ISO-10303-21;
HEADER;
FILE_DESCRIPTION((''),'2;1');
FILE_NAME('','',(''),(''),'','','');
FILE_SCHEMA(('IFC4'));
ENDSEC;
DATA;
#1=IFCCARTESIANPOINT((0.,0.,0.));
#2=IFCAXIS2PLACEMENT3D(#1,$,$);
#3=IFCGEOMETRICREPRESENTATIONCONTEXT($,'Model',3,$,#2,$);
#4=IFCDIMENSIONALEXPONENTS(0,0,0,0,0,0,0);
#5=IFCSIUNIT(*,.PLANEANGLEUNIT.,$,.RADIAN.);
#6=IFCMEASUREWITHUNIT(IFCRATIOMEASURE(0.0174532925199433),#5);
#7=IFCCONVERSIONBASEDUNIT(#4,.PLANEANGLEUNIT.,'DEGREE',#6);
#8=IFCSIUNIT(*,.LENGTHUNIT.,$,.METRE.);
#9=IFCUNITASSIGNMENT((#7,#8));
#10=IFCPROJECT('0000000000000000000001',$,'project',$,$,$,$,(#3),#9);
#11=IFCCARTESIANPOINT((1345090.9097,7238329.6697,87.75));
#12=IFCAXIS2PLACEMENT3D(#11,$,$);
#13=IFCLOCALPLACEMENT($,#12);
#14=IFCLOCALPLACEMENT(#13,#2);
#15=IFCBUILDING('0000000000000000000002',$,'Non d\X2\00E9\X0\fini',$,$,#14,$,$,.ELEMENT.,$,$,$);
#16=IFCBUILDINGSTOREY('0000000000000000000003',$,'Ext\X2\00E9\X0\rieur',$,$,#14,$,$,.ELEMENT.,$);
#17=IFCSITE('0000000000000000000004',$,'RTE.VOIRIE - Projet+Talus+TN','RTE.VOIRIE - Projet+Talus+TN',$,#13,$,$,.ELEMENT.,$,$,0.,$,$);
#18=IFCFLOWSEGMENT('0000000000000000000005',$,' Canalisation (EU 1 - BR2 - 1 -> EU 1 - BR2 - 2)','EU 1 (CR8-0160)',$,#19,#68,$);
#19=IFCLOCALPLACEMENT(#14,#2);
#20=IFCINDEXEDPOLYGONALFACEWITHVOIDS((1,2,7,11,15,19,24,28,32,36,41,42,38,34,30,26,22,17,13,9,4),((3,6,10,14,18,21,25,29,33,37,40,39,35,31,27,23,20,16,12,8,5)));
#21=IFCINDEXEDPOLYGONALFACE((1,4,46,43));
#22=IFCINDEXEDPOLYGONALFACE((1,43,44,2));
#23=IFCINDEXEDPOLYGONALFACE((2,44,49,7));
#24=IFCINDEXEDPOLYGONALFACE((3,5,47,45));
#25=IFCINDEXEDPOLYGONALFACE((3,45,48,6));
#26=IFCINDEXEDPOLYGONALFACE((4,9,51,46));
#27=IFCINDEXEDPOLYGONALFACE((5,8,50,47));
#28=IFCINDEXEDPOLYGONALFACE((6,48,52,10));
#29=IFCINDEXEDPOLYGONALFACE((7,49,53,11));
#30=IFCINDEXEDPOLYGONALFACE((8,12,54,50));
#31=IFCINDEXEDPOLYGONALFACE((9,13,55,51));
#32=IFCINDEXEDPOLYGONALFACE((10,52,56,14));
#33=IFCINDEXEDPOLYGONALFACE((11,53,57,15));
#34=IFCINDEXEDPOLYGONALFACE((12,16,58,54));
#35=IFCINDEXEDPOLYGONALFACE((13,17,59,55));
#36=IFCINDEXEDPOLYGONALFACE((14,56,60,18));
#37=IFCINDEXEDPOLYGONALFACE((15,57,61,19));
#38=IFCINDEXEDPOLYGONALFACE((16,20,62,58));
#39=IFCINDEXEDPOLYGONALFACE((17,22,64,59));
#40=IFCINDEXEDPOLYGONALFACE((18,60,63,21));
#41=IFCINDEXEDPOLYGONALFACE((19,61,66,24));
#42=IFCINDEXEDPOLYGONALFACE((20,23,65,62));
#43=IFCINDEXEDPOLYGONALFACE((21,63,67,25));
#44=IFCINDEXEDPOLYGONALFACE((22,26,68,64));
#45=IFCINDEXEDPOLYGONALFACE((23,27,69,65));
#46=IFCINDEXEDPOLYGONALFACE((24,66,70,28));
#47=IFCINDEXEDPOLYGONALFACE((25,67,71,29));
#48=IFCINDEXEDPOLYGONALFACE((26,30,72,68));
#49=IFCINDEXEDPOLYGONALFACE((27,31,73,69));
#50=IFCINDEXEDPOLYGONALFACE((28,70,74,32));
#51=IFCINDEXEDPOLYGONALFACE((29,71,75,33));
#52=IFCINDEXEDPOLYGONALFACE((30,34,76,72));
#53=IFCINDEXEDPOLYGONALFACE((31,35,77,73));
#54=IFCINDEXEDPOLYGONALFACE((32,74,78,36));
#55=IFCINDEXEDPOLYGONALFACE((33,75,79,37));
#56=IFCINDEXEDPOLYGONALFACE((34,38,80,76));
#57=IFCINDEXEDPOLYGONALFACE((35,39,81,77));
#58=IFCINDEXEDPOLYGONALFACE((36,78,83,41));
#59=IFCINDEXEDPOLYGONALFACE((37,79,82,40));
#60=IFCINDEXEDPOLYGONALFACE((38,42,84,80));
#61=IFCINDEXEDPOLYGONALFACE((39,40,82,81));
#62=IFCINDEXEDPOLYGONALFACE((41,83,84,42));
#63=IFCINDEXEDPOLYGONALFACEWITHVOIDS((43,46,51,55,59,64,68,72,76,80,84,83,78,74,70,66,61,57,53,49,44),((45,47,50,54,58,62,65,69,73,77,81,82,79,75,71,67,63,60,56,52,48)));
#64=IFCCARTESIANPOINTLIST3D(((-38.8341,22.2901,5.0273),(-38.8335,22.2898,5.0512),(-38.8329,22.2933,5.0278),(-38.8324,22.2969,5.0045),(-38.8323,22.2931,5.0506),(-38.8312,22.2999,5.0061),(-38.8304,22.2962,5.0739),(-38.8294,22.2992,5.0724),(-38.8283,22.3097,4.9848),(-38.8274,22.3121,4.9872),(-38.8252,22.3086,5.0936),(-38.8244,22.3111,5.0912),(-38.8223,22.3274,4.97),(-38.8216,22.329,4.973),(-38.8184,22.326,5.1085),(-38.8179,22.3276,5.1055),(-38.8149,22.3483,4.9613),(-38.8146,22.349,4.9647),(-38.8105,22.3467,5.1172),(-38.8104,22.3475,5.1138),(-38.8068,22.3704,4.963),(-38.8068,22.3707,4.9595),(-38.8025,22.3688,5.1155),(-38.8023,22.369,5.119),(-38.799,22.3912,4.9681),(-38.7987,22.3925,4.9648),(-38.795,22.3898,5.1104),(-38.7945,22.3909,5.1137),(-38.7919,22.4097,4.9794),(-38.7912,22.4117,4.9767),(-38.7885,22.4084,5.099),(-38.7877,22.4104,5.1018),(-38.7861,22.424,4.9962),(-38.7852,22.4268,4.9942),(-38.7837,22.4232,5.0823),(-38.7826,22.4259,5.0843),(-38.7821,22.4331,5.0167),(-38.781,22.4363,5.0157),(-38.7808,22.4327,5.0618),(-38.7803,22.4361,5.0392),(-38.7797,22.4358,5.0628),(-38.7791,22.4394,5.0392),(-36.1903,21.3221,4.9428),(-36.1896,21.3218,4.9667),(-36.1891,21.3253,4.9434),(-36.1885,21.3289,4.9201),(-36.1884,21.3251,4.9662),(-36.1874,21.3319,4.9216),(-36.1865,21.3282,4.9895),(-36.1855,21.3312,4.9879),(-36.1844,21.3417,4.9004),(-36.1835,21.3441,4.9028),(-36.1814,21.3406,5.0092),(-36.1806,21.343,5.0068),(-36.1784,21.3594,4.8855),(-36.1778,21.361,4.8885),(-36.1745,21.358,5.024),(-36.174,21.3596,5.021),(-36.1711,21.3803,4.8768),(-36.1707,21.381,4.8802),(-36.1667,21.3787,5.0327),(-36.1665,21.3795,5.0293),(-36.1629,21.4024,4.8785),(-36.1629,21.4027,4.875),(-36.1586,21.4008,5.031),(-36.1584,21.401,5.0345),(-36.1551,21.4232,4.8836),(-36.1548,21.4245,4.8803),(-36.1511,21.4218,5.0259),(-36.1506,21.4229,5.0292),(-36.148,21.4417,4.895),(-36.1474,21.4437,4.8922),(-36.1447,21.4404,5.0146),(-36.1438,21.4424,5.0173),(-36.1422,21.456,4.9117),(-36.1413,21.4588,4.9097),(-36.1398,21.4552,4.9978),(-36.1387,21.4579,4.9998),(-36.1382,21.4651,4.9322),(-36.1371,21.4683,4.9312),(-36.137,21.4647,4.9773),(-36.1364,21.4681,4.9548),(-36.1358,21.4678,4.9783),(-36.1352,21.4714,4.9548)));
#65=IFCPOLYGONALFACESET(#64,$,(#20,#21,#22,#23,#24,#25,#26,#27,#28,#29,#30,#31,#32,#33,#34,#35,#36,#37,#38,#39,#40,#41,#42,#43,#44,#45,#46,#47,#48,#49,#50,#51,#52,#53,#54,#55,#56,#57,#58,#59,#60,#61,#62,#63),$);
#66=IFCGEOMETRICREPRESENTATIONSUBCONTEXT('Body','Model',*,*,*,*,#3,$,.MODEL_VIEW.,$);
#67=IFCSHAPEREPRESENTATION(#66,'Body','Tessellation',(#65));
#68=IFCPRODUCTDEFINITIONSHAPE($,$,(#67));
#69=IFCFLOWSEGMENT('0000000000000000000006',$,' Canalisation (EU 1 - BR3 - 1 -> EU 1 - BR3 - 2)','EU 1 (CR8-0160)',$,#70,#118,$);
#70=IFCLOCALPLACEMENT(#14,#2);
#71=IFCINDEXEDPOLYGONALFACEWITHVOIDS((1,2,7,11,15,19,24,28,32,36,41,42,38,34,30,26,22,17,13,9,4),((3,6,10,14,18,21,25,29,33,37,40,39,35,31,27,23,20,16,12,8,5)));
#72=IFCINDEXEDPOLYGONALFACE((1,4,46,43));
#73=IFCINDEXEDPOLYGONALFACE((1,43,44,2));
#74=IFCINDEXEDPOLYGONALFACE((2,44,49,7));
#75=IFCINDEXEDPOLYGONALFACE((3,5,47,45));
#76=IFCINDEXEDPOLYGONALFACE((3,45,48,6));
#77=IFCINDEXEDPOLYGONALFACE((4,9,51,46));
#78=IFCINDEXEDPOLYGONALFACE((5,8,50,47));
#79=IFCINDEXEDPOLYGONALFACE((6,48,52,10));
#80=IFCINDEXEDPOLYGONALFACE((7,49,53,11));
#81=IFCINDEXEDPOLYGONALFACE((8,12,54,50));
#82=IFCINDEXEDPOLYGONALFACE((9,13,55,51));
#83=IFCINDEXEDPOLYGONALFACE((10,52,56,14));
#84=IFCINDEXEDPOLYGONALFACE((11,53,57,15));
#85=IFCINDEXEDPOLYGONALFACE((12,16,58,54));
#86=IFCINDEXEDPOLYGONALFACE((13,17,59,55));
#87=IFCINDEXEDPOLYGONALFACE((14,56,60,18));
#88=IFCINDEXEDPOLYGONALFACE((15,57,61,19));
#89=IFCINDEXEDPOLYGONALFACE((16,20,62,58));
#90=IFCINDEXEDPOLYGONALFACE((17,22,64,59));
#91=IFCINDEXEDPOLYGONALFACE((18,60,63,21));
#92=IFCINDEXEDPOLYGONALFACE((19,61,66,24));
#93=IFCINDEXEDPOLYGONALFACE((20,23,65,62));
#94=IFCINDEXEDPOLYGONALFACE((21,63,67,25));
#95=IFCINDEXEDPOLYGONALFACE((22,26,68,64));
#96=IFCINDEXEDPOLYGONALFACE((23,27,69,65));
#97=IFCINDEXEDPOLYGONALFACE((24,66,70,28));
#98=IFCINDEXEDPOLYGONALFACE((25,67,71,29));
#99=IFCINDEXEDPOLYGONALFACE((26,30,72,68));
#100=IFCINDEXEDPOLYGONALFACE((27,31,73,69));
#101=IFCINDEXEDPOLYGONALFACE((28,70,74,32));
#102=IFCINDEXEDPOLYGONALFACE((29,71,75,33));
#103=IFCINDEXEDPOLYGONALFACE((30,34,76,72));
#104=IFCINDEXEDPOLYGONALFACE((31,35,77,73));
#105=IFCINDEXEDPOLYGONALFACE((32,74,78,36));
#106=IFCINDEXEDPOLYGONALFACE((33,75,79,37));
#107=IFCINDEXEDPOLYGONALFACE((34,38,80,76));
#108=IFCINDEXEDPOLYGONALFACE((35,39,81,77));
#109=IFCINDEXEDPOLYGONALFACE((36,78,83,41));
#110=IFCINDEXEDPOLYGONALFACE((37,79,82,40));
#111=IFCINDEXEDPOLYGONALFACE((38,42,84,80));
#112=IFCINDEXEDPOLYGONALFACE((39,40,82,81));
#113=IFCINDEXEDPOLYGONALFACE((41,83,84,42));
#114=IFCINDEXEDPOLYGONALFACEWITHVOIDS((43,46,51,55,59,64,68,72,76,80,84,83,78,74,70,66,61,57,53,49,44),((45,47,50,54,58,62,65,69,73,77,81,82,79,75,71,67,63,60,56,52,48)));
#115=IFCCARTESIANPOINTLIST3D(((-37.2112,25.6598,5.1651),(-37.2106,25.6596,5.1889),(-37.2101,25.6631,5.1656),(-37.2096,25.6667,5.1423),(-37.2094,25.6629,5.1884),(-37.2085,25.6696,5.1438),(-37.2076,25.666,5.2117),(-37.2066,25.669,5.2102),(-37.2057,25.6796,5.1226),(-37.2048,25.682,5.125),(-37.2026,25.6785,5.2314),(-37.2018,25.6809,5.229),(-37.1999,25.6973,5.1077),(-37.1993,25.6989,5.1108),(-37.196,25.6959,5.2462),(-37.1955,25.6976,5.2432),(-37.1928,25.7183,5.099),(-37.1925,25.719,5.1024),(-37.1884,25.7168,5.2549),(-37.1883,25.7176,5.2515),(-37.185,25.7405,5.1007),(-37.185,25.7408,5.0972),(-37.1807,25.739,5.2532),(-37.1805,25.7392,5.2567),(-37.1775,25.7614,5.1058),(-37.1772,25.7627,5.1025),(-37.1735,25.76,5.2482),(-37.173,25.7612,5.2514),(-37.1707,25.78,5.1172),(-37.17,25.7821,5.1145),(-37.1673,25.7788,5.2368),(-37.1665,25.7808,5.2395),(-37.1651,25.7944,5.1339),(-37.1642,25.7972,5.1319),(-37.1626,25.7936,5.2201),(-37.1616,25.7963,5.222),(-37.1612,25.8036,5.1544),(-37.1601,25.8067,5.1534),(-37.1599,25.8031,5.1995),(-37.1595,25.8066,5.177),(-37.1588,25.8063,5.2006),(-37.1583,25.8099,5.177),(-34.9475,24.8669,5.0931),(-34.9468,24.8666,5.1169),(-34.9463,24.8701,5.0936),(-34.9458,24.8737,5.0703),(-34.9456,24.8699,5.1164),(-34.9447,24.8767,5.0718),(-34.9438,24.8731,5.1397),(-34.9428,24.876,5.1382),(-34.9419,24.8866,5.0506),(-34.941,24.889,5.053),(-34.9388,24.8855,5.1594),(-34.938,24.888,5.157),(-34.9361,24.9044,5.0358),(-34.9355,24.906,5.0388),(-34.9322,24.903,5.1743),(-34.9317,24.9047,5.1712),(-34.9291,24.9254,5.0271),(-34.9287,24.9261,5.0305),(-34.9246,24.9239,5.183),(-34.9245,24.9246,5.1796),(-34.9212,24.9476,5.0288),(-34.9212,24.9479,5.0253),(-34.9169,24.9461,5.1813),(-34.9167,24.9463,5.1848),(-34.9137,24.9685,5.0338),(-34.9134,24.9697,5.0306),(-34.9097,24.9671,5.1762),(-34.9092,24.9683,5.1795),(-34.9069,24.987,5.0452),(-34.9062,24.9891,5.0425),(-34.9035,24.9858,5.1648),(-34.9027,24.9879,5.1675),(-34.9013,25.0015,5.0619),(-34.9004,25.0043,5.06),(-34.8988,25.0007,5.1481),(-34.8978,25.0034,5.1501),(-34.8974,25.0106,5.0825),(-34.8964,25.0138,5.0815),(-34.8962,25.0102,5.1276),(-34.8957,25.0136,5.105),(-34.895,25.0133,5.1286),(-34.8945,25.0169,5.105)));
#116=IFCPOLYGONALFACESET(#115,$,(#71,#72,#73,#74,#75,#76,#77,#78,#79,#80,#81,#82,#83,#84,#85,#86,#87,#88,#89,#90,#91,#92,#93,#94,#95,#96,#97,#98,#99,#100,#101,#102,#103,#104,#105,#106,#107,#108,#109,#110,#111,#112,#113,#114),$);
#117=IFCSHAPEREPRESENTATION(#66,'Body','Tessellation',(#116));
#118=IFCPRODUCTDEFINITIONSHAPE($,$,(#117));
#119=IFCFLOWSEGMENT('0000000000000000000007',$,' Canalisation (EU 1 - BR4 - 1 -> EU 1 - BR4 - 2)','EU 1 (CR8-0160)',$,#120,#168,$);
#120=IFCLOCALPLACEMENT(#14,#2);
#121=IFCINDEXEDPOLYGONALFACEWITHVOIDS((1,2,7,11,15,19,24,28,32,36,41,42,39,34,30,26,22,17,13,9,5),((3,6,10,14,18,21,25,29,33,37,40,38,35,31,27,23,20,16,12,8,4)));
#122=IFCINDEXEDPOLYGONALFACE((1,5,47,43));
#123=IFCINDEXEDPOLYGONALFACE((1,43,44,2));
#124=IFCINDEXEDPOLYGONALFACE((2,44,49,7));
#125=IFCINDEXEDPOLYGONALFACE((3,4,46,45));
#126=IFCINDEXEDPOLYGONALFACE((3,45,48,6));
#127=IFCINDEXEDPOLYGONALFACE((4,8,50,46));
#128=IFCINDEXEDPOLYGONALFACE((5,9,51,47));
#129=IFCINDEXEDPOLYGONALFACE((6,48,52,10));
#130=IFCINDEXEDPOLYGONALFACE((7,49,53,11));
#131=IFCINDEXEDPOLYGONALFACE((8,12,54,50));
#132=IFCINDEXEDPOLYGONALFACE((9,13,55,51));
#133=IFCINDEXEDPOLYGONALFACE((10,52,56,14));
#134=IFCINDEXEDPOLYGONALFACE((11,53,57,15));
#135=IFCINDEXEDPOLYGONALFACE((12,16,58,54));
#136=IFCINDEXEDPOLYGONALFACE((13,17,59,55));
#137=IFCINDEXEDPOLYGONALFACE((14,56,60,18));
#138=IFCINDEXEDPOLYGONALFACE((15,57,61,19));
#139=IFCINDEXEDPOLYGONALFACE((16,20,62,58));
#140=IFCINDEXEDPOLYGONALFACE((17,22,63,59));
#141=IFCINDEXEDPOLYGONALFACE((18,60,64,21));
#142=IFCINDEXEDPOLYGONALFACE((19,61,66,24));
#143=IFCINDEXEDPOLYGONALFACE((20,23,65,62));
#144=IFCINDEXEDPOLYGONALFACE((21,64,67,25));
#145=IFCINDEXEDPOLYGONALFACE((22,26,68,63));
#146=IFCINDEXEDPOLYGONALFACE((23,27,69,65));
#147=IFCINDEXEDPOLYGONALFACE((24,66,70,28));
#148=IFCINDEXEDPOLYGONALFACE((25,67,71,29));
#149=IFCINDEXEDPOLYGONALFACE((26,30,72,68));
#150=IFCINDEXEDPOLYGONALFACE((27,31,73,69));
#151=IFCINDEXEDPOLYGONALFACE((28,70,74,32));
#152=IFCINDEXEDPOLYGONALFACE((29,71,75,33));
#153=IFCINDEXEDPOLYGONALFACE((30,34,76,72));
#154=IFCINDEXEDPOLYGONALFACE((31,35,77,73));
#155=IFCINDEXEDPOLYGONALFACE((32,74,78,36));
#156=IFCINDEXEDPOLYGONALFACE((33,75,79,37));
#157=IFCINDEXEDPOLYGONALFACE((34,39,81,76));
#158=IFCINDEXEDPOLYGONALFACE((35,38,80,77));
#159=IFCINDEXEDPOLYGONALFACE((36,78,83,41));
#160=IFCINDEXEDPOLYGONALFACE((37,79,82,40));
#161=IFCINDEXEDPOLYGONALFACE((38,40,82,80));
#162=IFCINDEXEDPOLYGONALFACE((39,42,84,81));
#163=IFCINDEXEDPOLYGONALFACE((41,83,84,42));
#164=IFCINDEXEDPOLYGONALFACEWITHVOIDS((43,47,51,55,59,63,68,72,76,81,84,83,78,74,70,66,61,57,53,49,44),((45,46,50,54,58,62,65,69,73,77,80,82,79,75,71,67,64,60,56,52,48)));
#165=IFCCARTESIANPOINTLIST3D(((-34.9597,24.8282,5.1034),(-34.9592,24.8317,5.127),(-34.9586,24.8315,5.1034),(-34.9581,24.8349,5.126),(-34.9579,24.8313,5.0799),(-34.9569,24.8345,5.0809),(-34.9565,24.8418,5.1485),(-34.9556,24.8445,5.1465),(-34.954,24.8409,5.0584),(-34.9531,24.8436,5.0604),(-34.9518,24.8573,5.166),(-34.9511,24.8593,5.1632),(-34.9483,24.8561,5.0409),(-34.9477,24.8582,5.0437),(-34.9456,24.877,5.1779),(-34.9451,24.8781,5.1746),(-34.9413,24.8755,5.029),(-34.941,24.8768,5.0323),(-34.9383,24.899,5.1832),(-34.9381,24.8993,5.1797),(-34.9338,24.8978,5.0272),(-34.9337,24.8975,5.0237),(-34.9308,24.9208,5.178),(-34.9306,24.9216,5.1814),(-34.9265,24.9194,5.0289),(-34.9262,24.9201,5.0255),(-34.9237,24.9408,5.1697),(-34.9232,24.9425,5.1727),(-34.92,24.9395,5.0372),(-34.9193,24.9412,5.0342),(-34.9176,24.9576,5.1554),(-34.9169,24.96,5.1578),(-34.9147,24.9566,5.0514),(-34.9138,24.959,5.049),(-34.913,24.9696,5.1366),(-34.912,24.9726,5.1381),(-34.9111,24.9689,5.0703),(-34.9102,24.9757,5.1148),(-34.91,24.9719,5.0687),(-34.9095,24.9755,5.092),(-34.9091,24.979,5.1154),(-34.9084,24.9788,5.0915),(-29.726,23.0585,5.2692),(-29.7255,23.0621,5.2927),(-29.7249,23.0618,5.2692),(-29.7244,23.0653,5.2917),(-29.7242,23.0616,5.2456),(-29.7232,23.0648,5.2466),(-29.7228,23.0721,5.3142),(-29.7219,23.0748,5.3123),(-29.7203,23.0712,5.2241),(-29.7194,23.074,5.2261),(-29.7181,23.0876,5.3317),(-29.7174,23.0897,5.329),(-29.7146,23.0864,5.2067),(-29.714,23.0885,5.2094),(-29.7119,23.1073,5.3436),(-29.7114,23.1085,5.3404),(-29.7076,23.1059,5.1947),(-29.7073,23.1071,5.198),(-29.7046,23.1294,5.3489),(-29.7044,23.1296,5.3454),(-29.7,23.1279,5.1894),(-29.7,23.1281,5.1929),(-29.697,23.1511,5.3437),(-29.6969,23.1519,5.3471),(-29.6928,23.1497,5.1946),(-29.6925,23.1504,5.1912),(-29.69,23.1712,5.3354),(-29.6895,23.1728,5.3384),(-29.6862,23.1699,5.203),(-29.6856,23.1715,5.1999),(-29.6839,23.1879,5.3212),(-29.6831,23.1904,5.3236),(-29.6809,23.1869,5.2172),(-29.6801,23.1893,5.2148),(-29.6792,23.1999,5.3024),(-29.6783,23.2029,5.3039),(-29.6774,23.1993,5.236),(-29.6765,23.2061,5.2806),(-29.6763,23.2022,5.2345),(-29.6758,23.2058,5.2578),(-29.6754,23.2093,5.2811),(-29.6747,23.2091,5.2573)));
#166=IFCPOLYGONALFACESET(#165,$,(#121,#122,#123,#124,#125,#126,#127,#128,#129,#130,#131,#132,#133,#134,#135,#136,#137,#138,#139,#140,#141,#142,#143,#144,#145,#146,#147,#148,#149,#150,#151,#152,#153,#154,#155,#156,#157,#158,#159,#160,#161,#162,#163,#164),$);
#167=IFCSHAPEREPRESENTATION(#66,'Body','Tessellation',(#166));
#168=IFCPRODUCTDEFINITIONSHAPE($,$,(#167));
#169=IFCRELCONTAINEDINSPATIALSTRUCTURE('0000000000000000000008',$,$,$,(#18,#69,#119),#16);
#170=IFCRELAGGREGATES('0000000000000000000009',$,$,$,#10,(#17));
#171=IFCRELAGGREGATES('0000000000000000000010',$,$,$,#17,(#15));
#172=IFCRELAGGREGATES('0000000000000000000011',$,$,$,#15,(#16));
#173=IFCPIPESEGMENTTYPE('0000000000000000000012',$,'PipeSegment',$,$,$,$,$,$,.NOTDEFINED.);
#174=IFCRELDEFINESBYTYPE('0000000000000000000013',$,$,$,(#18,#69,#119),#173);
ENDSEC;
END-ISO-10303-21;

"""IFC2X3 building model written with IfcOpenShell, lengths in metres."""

from ifc_helpers import new_model, entity, si_unit, converted_unit, frame, origin, origin_2d_with_axis, place, context, subcontext, project, spatial, hollow_circle, extrude, type_object, element, save


model = new_model("IFC2X3")

# Units and contexts
model_context = context("Model", 3, world=origin())
body_context = subcontext(model_context, "Body", "Model", "MODEL_VIEW")
ifc_project = project(units=[converted_unit("PLANEANGLEUNIT", "DEGREE", entity("IfcRatioMeasure", 0.0174532925199433), si_unit("PLANEANGLEUNIT", "RADIAN"), dimensions=[0, 0, 0, 0, 0, 0, 0]), si_unit("LENGTHUNIT", "METRE")], contexts=[model_context])

# Site, building, storey
site_placement = place(None, frame((1345090.9097, 7238329.6697, 87.75)))
site = spatial("IfcSite", under=ifc_project, at=site_placement, Name="RTE.VOIRIE - Projet+Talus+TN", Description="RTE.VOIRIE - Projet+Talus+TN", CompositionType="ELEMENT", RefElevation=0.0)
placement = place(site_placement, origin())
building = spatial("IfcBuilding", under=site, at=placement, Name="Non défini", CompositionType="ELEMENT")
storey = spatial("IfcBuildingStorey", under=building, at=placement, Name="Extérieur", CompositionType="ELEMENT")

# Flow segments
pipe_segment_type_1 = type_object("IfcPipeSegmentType", Name="PipeSegment", PredefinedType="NOTDEFINED")
flow_segment_1_placement = place(placement, origin())
element("IfcFlowSegment", 1, at=flow_segment_1_placement, inside=storey, type_object=pipe_segment_type_1, Name=" Canalisation (EU 1 - BR2 - 1 -> EU 1 - BR2 - 2)", Description="EU 1 (CR8-0160)", context=body_context, shape_type="SweptSolid", body=[
    extrude(hollow_circle(Radius=0.08, WallThickness=0.0035, at=origin_2d_with_axis()), frame((-38.8066, 22.3642, 5.0392), z_axis=(0.938617, -0.343655, -0.029987), x_axis=(0.343655, 0.938617, 0.0)), (0.0, 0.0, 1.0), 2.8168),
])
flow_segment_2_placement = place(placement, origin())
element("IfcFlowSegment", 2, at=flow_segment_2_placement, inside=storey, type_object=pipe_segment_type_1, Name=" Canalisation (EU 1 - BR3 - 1 -> EU 1 - BR3 - 2)", Description="EU 1 (CR8-0160)", context=body_context, shape_type="SweptSolid", body=[
    extrude(hollow_circle(Radius=0.08, WallThickness=0.0035, at=origin_2d_with_axis()), frame((-37.1848, 25.7344, 5.177), z_axis=(0.943354, -0.33043, -0.029987), x_axis=(0.33043, 0.943354, 0.0)), (0.0, 0.0, 1.0), 2.3997),
])
flow_segment_3_placement = place(placement, origin())
element("IfcFlowSegment", 3, at=flow_segment_3_placement, inside=storey, type_object=pipe_segment_type_1, Name=" Canalisation (EU 1 - BR4 - 1 -> EU 1 - BR4 - 2)", Description="EU 1 (CR8-0160)", context=body_context, shape_type="SweptSolid", body=[
    extrude(hollow_circle(Radius=0.08, WallThickness=0.0035, at=origin_2d_with_axis()), frame((-29.7004, 23.1343, 5.2692), z_axis=(-0.946887, 0.320166, -0.029987), x_axis=(-0.320166, -0.946887, 0.0)), (0.0, 0.0, 1.0), 5.5273),
])

save(model, "model.ifc")
